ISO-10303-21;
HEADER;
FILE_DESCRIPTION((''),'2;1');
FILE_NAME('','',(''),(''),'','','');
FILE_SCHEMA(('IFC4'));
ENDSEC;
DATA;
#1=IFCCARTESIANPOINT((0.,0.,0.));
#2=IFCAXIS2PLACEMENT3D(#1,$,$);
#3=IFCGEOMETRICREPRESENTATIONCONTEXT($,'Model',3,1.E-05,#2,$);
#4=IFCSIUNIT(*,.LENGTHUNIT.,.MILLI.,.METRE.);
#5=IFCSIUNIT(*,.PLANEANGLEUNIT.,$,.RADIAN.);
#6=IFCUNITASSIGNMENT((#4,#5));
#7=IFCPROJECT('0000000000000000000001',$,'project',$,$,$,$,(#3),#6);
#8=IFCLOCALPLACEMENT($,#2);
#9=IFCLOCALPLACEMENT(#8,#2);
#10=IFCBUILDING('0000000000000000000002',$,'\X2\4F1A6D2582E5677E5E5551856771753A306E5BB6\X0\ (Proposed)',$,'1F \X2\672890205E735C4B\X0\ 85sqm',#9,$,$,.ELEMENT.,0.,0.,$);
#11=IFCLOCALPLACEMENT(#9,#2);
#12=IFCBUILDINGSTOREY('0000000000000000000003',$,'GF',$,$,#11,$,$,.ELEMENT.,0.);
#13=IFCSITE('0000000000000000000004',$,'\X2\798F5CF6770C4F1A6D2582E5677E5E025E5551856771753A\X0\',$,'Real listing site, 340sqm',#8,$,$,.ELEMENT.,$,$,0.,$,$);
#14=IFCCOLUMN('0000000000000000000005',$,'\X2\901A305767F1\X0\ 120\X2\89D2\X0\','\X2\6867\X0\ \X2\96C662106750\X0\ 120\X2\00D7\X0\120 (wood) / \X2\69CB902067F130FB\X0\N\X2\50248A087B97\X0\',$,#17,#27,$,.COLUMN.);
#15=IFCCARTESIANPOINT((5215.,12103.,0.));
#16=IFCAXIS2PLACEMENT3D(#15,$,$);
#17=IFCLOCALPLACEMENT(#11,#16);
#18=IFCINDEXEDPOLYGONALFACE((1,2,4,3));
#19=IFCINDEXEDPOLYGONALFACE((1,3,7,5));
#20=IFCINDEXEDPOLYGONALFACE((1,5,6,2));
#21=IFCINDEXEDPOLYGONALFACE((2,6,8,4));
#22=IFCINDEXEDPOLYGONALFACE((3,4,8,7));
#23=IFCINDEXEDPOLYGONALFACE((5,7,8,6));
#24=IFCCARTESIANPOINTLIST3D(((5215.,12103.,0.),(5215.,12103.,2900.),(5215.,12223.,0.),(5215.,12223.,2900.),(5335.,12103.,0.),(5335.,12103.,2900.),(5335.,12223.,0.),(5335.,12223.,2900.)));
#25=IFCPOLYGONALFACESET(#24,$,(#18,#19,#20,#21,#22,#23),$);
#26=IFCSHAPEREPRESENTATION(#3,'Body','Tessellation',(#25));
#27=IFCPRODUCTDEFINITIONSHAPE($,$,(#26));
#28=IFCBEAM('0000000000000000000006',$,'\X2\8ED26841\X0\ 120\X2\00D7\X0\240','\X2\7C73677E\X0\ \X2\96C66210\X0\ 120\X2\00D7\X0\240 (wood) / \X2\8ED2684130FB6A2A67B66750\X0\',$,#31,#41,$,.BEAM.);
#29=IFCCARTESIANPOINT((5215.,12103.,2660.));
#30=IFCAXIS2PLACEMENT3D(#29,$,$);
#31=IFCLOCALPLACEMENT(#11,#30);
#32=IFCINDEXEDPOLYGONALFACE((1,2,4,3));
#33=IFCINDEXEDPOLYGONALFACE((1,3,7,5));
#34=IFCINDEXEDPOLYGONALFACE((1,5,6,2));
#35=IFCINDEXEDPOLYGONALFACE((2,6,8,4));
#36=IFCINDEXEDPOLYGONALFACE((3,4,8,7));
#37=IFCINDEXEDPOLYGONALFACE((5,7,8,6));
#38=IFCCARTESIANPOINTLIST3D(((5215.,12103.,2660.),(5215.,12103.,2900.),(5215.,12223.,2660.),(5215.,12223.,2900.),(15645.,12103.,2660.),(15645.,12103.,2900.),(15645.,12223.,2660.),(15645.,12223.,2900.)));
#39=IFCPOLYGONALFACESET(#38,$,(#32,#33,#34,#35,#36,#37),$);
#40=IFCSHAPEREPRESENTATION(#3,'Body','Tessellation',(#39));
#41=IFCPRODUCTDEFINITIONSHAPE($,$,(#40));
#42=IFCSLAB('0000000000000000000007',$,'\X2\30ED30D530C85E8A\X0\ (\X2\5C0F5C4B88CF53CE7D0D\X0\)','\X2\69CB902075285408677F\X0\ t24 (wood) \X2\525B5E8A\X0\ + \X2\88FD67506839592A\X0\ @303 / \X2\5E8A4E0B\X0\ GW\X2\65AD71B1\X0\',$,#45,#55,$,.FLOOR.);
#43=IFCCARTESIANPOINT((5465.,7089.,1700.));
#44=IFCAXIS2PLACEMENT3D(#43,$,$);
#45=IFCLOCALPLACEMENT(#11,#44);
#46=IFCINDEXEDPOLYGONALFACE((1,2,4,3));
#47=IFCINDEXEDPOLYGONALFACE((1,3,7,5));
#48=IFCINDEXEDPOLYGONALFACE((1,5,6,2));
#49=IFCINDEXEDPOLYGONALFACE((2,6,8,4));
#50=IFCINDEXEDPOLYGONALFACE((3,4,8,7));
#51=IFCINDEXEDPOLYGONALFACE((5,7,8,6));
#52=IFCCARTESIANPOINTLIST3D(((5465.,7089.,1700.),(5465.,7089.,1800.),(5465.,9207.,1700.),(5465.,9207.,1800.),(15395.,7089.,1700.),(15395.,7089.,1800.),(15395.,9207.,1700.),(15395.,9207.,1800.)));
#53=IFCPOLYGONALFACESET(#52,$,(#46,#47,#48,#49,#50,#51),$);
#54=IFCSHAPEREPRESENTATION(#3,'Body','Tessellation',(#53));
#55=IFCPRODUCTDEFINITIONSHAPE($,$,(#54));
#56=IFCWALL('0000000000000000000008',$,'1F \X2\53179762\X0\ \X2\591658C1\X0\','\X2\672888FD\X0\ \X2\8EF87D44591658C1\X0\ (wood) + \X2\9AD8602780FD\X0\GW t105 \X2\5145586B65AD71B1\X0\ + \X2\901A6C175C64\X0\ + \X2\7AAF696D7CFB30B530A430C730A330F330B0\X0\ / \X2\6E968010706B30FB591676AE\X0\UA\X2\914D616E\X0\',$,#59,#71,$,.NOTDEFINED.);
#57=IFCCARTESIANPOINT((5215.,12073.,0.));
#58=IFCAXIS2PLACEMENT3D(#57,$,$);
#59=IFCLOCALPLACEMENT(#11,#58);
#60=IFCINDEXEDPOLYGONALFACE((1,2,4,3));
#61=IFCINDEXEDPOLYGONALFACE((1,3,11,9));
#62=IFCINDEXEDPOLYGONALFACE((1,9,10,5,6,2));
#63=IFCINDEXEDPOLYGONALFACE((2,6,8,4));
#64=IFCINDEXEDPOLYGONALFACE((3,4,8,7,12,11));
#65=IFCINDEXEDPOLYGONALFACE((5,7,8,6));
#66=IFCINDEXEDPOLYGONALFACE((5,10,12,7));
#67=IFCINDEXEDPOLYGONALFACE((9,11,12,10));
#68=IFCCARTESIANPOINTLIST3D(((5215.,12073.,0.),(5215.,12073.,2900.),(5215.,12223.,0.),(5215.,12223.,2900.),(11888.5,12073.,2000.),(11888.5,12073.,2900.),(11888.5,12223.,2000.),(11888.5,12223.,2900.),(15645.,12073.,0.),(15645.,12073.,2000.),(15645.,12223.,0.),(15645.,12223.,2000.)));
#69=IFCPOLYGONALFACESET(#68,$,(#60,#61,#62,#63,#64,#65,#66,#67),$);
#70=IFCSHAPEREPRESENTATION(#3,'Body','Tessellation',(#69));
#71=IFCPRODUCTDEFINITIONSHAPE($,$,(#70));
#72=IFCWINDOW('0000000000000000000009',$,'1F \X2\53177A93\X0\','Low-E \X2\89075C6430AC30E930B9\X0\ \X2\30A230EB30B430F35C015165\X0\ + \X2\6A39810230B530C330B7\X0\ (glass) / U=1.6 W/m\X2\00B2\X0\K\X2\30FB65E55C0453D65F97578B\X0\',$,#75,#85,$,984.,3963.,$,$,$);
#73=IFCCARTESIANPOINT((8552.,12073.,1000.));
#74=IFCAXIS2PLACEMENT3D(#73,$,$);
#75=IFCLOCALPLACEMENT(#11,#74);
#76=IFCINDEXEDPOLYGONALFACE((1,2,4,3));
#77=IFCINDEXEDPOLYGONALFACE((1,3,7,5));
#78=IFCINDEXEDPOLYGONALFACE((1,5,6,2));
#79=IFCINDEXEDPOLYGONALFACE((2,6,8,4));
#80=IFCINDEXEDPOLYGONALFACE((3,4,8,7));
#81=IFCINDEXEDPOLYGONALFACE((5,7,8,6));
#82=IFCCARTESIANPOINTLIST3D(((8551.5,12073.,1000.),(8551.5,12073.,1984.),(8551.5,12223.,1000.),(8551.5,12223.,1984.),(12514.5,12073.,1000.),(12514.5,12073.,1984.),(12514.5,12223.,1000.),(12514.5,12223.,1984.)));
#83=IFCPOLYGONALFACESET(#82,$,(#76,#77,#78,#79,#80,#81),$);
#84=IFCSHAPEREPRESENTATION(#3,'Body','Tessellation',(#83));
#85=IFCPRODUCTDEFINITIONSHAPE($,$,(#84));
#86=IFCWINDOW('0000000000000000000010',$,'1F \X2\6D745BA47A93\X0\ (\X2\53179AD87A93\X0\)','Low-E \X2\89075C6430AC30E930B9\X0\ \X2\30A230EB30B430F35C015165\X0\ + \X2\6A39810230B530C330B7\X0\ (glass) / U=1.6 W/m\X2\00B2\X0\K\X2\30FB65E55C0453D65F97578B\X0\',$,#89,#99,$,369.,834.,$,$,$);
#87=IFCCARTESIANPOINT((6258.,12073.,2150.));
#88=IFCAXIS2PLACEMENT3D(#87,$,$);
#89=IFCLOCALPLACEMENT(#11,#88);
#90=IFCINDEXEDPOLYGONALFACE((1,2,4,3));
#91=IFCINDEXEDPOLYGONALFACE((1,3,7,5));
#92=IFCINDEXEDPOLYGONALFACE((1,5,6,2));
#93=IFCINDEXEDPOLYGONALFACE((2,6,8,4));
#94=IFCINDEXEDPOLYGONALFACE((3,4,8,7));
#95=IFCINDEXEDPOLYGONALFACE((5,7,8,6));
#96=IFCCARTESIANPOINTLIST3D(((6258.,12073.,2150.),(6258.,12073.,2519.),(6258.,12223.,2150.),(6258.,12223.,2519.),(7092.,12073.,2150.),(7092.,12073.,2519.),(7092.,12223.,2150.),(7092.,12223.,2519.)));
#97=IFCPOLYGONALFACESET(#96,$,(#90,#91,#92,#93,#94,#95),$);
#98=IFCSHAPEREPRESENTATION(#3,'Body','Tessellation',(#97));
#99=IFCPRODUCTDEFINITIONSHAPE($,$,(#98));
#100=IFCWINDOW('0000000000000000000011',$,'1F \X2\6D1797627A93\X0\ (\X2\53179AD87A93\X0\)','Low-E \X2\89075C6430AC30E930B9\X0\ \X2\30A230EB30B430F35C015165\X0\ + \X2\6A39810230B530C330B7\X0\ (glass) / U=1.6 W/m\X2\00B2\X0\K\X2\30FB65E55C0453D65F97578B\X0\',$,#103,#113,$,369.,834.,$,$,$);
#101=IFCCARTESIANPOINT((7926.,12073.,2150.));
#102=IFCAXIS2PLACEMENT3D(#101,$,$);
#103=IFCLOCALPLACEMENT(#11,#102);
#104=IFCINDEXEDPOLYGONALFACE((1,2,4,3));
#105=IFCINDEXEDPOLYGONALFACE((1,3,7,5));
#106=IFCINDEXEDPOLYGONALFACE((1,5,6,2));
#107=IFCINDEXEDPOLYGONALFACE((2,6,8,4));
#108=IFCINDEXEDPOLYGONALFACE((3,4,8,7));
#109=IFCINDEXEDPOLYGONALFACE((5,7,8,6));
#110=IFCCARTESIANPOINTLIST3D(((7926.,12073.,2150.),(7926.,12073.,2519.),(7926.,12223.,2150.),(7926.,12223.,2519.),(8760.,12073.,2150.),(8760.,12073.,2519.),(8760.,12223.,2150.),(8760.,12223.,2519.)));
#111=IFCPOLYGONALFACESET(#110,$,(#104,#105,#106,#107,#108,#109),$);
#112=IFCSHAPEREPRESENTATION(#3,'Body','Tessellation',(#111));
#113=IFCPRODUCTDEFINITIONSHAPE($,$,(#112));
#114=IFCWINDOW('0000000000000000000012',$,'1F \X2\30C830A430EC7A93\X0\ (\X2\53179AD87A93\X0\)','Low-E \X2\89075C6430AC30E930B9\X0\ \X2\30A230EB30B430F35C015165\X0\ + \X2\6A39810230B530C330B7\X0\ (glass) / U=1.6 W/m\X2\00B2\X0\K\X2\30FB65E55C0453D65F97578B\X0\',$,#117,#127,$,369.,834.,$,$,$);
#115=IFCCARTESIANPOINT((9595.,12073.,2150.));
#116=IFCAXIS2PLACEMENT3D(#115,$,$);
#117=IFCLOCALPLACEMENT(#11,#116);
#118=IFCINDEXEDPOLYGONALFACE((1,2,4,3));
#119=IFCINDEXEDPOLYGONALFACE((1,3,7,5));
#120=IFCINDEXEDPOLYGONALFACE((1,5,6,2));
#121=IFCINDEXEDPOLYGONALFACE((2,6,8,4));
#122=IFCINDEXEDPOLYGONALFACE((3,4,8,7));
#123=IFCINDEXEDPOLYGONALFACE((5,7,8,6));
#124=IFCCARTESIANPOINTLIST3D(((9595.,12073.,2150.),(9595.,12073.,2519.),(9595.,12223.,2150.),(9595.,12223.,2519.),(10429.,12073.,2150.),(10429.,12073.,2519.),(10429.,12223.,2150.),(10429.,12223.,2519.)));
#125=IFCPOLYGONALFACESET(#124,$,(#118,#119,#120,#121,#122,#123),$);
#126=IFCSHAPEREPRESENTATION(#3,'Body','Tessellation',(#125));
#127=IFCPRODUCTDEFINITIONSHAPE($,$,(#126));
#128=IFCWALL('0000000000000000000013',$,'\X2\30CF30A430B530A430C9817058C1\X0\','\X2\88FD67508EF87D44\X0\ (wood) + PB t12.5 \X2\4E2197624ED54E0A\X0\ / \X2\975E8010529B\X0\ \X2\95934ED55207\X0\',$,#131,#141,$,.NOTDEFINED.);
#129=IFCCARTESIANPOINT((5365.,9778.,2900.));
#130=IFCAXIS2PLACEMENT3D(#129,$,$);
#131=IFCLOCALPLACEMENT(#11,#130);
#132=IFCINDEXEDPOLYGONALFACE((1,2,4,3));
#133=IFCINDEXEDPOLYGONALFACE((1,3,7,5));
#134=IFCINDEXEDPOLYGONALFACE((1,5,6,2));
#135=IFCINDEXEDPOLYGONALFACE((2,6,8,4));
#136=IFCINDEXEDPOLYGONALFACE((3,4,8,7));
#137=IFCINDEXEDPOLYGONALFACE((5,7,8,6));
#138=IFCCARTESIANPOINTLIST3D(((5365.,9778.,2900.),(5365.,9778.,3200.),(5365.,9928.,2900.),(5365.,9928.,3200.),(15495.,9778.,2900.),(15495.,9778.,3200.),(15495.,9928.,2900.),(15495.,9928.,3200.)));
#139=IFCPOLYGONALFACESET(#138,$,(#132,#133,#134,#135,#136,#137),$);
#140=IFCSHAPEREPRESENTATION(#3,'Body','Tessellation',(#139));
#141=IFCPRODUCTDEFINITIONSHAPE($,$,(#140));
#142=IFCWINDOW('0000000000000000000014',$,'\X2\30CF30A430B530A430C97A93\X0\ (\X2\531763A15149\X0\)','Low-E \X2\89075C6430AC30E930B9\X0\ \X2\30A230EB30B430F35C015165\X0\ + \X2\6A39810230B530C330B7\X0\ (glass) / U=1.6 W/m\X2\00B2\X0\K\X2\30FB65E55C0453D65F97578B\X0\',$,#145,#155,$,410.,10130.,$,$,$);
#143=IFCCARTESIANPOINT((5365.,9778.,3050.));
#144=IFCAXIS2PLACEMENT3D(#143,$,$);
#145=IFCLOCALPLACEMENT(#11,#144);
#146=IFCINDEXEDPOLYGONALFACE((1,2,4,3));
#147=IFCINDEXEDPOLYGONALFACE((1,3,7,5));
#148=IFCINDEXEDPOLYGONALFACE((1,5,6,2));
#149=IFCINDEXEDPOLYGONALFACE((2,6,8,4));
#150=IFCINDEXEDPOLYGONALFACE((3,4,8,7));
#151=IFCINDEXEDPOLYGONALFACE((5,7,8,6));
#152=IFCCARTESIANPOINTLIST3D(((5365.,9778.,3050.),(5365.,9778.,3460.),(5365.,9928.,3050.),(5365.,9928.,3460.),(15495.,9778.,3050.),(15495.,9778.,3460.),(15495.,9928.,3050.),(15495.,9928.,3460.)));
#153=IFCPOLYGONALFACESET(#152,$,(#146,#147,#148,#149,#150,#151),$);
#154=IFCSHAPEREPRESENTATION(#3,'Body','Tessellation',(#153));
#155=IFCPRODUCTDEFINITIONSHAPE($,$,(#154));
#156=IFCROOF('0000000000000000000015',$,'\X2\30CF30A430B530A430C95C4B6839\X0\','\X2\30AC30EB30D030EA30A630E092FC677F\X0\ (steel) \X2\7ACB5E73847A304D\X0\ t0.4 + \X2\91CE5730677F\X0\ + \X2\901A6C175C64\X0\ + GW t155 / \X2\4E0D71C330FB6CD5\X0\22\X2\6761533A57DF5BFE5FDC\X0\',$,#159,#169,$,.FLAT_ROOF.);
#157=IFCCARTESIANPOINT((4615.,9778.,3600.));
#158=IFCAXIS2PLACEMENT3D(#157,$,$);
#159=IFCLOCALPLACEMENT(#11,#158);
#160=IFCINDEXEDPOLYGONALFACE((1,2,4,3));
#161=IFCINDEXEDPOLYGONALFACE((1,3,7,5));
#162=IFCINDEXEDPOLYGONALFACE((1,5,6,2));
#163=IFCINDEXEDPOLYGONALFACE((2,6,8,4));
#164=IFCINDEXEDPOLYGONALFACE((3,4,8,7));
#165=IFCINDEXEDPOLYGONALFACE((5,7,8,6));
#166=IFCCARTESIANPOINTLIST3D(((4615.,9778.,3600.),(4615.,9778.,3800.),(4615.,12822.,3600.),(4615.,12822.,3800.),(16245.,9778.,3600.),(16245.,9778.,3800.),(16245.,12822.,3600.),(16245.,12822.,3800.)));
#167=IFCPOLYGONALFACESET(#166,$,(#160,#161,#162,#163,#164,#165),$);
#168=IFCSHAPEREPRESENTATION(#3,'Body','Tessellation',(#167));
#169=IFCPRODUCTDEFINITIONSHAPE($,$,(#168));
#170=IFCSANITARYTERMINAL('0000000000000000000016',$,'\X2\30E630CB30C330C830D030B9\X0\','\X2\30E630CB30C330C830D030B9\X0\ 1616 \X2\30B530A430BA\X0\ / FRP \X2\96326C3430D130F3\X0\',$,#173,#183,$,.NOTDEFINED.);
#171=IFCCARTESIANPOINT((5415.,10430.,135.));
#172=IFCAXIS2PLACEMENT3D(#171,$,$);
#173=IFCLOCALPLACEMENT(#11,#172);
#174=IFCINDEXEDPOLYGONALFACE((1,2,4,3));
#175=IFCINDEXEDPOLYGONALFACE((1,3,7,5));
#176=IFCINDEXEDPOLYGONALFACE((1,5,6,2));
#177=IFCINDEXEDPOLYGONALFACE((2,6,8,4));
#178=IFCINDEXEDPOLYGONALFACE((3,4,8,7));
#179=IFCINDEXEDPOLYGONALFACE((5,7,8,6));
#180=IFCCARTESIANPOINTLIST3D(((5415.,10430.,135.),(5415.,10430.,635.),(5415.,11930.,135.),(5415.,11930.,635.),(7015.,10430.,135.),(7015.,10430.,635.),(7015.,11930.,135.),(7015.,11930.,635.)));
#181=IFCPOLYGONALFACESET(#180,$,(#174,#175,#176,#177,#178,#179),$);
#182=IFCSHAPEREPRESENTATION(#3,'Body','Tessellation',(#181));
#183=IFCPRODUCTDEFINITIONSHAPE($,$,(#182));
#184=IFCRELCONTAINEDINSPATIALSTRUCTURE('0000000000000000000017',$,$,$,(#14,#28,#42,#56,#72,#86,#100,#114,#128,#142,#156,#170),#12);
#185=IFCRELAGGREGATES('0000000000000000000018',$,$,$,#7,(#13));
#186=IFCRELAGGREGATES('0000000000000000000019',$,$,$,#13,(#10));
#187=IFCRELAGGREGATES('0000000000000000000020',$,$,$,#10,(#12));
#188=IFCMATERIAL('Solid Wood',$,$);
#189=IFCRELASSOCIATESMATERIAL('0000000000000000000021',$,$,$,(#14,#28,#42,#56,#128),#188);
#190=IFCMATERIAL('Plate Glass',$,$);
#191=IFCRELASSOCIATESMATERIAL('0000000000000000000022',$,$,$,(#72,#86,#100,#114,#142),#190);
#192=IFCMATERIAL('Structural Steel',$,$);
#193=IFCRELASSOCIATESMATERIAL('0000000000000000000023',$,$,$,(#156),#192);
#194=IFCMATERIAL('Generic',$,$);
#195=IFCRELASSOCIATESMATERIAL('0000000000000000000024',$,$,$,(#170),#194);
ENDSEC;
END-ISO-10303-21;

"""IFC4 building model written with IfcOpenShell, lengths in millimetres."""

from ifc_helpers import new_model, si_unit, frame, frame_2d, origin, place, context, project, spatial, rectangle, extrude, material, element, fill, save


model = new_model("IFC4")

# Units and contexts
model_context = context("Model", 3, precision=1e-05, world=origin())
ifc_project = project(units=[si_unit("LENGTHUNIT", "METRE", prefix="MILLI"), si_unit("PLANEANGLEUNIT", "RADIAN")], contexts=[model_context])

# Site, building, storey
site_placement = place(None, origin())
site = spatial("IfcSite", under=ifc_project, at=site_placement, Name="福島県会津若松市幕内東町", ObjectType="Real listing site, 340sqm", CompositionType="ELEMENT", RefElevation=0.0)
building_placement = place(site_placement, origin())
building = spatial("IfcBuilding", under=site, at=building_placement, Name="会津若松幕内東町の家 (Proposed)", ObjectType="1F 木造平屋 85sqm", CompositionType="ELEMENT", ElevationOfRefHeight=0.0, ElevationOfTerrain=0.0)
storey_placement = place(building_placement, origin())
storey = spatial("IfcBuildingStorey", under=building, at=storey_placement, Name="GF", CompositionType="ELEMENT", Elevation=0.0)

# Column
ifc_material_1 = material(Name="Solid Wood")
column_1_placement = place(storey_placement, frame((5215.0, 12103.0, 0.0)))
element("IfcColumn", 1, at=column_1_placement, inside=storey, material=ifc_material_1, Name="通し柱 120角", Description="桧 集成材 120×120 (wood) / 構造柱・N値計算", PredefinedType="COLUMN", context=model_context, shape_type="SweptSolid", body=[
    extrude(rectangle(XDim=120.0, YDim=120.0, at=frame_2d((60.0, 60.0))), frame((5215.0, 12103.0, 0.0)), (0.0, 0.0, 1.0), 2900.0),
])

# Beam
beam_1_placement = place(storey_placement, frame((5215.0, 12103.0, 2660.0)))
element("IfcBeam", 2, at=beam_1_placement, inside=storey, material=ifc_material_1, Name="軒桁 120×240", Description="米松 集成 120×240 (wood) / 軒桁・横架材", PredefinedType="BEAM", context=model_context, shape_type="SweptSolid", body=[
    extrude(rectangle(XDim=10430.0, YDim=120.0, at=frame_2d((5215.0, 60.0))), frame((5215.0, 12103.0, 2660.0)), (0.0, 0.0, 1.0), 240.0),
])

# Slab
slab_placement = place(storey_placement, frame((5465.0, 7089.0, 1700.0)))
element("IfcSlab", 3, at=slab_placement, inside=storey, material=ifc_material_1, Name="ロフト床 (小屋裏収納)", Description="構造用合板 t24 (wood) 剛床 + 製材根太 @303 / 床下 GW断熱", PredefinedType="FLOOR", context=model_context, shape_type="SweptSolid", body=[
    extrude(rectangle(XDim=9930.0, YDim=2118.0, at=frame_2d((4965.0, 1059.0))), frame((5465.0, 7089.0, 1700.0)), (0.0, 0.0, 1.0), 100.0),
])

# Wall, openings, windows
wall_1_placement = place(storey_placement, frame((5215.0, 12073.0, 0.0)))
wall_1 = element("IfcWall", 4, at=wall_1_placement, inside=storey, material=ifc_material_1, Name="1F 北面 外壁", Description="木製 軸組外壁 (wood) + 高性能GW t105 充填断熱 + 通気層 + 窯業系サイディング / 準耐火・外皮UA配慮", PredefinedType="NOTDEFINED", context=model_context, shape_type="SweptSolid", body=[
    extrude(rectangle(XDim=10430.0, YDim=150.0, at=frame_2d((5215.0, 75.0))), frame((5215.0, 12073.0, 0.0)), (0.0, 0.0, 1.0), 2900.0),
])
opening_1_placement = place(storey_placement, frame((8552.0, 12073.0, 1000.0)))
opening_1 = element("IfcOpeningElement", 5, at=opening_1_placement, cuts=wall_1, PredefinedType="NOTDEFINED", context=model_context, shape_type="SweptSolid", body=[
    extrude(rectangle(XDim=3963.0, YDim=150.0, at=frame_2d((1981.0, 75.0))), frame((8552.0, 12073.0, 1000.0)), (0.0, 0.0, 1.0), 984.0),
])
opening_2_placement = place(storey_placement, frame((6258.0, 12073.0, 2150.0)))
opening_2 = element("IfcOpeningElement", 6, at=opening_2_placement, cuts=wall_1, PredefinedType="NOTDEFINED", context=model_context, shape_type="SweptSolid", body=[
    extrude(rectangle(XDim=834.0, YDim=150.0, at=frame_2d((417.0, 75.0))), frame((6258.0, 12073.0, 2150.0)), (0.0, 0.0, 1.0), 369.0),
])
opening_3_placement = place(storey_placement, frame((7926.0, 12073.0, 2150.0)))
opening_3 = element("IfcOpeningElement", 7, at=opening_3_placement, cuts=wall_1, PredefinedType="NOTDEFINED", context=model_context, shape_type="SweptSolid", body=[
    extrude(rectangle(XDim=834.0, YDim=150.0, at=frame_2d((417.0, 75.0))), frame((7926.0, 12073.0, 2150.0)), (0.0, 0.0, 1.0), 369.0),
])
opening_4_placement = place(storey_placement, frame((9595.0, 12073.0, 2150.0)))
opening_4 = element("IfcOpeningElement", 8, at=opening_4_placement, cuts=wall_1, PredefinedType="NOTDEFINED", context=model_context, shape_type="SweptSolid", body=[
    extrude(rectangle(XDim=834.0, YDim=150.0, at=frame_2d((417.0, 75.0))), frame((9595.0, 12073.0, 2150.0)), (0.0, 0.0, 1.0), 369.0),
])
ifc_material_2 = material(Name="Plate Glass")
window_1_placement = place(storey_placement, frame((8552.0, 12073.0, 1000.0)))
window_1 = element("IfcWindow", 9, at=window_1_placement, inside=storey, material=ifc_material_2, Name="1F 北窓", Description="Low-E 複層ガラス アルゴン封入 + 樹脂サッシ (glass) / U=1.6 W/m²K・日射取得型", OverallHeight=984.0, OverallWidth=3963.0, context=model_context, shape_type="SweptSolid", body=[
    extrude(rectangle(XDim=3963.0, YDim=150.0, at=frame_2d((1981.0, 75.0))), frame((8552.0, 12073.0, 1000.0)), (0.0, 0.0, 1.0), 984.0),
])
fill(opening_1, window_1)
window_2_placement = place(storey_placement, frame((6258.0, 12073.0, 2150.0)))
window_2 = element("IfcWindow", 10, at=window_2_placement, inside=storey, material=ifc_material_2, Name="1F 浴室窓 (北高窓)", Description="Low-E 複層ガラス アルゴン封入 + 樹脂サッシ (glass) / U=1.6 W/m²K・日射取得型", OverallHeight=369.0, OverallWidth=834.0, context=model_context, shape_type="SweptSolid", body=[
    extrude(rectangle(XDim=834.0, YDim=150.0, at=frame_2d((417.0, 75.0))), frame((6258.0, 12073.0, 2150.0)), (0.0, 0.0, 1.0), 369.0),
])
fill(opening_2, window_2)
window_3_placement = place(storey_placement, frame((7926.0, 12073.0, 2150.0)))
window_3 = element("IfcWindow", 11, at=window_3_placement, inside=storey, material=ifc_material_2, Name="1F 洗面窓 (北高窓)", Description="Low-E 複層ガラス アルゴン封入 + 樹脂サッシ (glass) / U=1.6 W/m²K・日射取得型", OverallHeight=369.0, OverallWidth=834.0, context=model_context, shape_type="SweptSolid", body=[
    extrude(rectangle(XDim=834.0, YDim=150.0, at=frame_2d((417.0, 75.0))), frame((7926.0, 12073.0, 2150.0)), (0.0, 0.0, 1.0), 369.0),
])
fill(opening_3, window_3)
window_4_placement = place(storey_placement, frame((9595.0, 12073.0, 2150.0)))
window_4 = element("IfcWindow", 12, at=window_4_placement, inside=storey, material=ifc_material_2, Name="1F トイレ窓 (北高窓)", Description="Low-E 複層ガラス アルゴン封入 + 樹脂サッシ (glass) / U=1.6 W/m²K・日射取得型", OverallHeight=369.0, OverallWidth=834.0, context=model_context, shape_type="SweptSolid", body=[
    extrude(rectangle(XDim=834.0, YDim=150.0, at=frame_2d((417.0, 75.0))), frame((9595.0, 12073.0, 2150.0)), (0.0, 0.0, 1.0), 369.0),
])
fill(opening_4, window_4)

# Wall, opening, window
wall_2_placement = place(storey_placement, frame((5365.0, 9778.0, 2900.0)))
wall_2 = element("IfcWall", 13, at=wall_2_placement, inside=storey, material=ifc_material_1, Name="ハイサイド腰壁", Description="製材軸組 (wood) + PB t12.5 両面仕上 / 非耐力 間仕切", PredefinedType="NOTDEFINED", context=model_context, shape_type="SweptSolid", body=[
    extrude(rectangle(XDim=10130.0, YDim=150.0, at=frame_2d((5065.0, 75.0))), frame((5365.0, 9778.0, 2900.0)), (0.0, 0.0, 1.0), 700.0),
])
opening_5_placement = place(storey_placement, frame((5365.0, 9778.0, 3050.0)))
opening_5 = element("IfcOpeningElement", 14, at=opening_5_placement, cuts=wall_2, PredefinedType="NOTDEFINED", context=model_context, shape_type="SweptSolid", body=[
    extrude(rectangle(XDim=10130.0, YDim=150.0, at=frame_2d((5065.0, 75.0))), frame((5365.0, 9778.0, 3050.0)), (0.0, 0.0, 1.0), 410.0),
])
window_5_placement = place(storey_placement, frame((5365.0, 9778.0, 3050.0)))
window_5 = element("IfcWindow", 15, at=window_5_placement, inside=storey, material=ifc_material_2, Name="ハイサイド窓 (北採光)", Description="Low-E 複層ガラス アルゴン封入 + 樹脂サッシ (glass) / U=1.6 W/m²K・日射取得型", OverallHeight=410.0, OverallWidth=10130.0, context=model_context, shape_type="SweptSolid", body=[
    extrude(rectangle(XDim=10130.0, YDim=150.0, at=frame_2d((5065.0, 75.0))), frame((5365.0, 9778.0, 3050.0)), (0.0, 0.0, 1.0), 410.0),
])
fill(opening_5, window_5)

# Roof
ifc_material_3 = material(Name="Structural Steel")
roof_placement = place(storey_placement, frame((4615.0, 9778.0, 3600.0)))
element("IfcRoof", 16, at=roof_placement, inside=storey, material=ifc_material_3, Name="ハイサイド屋根", Description="ガルバリウム鋼板 (steel) 立平葺き t0.4 + 野地板 + 通気層 + GW t155 / 不燃・法22条区域対応", PredefinedType="FLAT_ROOF", context=model_context, shape_type="SweptSolid", body=[
    extrude(rectangle(XDim=11630.0, YDim=3044.0, at=frame_2d((5815.0, 1522.0))), frame((4615.0, 9778.0, 3600.0)), (0.0, 0.0, 1.0), 200.0),
])

# Sanitary terminal
ifc_material_4 = material(Name="Generic")
sanitary_terminal_placement = place(storey_placement, frame((5415.0, 10430.0, 135.0)))
element("IfcSanitaryTerminal", 17, at=sanitary_terminal_placement, inside=storey, material=ifc_material_4, Name="ユニットバス", Description="ユニットバス 1616 サイズ / FRP 防水パン", PredefinedType="NOTDEFINED", context=model_context, shape_type="SweptSolid", body=[
    extrude(rectangle(XDim=1600.0, YDim=1500.0, at=frame_2d((800.0, 750.0))), frame((5415.0, 10430.0, 135.0)), (0.0, 0.0, 1.0), 500.0),
])

save(model, "model.ifc")
